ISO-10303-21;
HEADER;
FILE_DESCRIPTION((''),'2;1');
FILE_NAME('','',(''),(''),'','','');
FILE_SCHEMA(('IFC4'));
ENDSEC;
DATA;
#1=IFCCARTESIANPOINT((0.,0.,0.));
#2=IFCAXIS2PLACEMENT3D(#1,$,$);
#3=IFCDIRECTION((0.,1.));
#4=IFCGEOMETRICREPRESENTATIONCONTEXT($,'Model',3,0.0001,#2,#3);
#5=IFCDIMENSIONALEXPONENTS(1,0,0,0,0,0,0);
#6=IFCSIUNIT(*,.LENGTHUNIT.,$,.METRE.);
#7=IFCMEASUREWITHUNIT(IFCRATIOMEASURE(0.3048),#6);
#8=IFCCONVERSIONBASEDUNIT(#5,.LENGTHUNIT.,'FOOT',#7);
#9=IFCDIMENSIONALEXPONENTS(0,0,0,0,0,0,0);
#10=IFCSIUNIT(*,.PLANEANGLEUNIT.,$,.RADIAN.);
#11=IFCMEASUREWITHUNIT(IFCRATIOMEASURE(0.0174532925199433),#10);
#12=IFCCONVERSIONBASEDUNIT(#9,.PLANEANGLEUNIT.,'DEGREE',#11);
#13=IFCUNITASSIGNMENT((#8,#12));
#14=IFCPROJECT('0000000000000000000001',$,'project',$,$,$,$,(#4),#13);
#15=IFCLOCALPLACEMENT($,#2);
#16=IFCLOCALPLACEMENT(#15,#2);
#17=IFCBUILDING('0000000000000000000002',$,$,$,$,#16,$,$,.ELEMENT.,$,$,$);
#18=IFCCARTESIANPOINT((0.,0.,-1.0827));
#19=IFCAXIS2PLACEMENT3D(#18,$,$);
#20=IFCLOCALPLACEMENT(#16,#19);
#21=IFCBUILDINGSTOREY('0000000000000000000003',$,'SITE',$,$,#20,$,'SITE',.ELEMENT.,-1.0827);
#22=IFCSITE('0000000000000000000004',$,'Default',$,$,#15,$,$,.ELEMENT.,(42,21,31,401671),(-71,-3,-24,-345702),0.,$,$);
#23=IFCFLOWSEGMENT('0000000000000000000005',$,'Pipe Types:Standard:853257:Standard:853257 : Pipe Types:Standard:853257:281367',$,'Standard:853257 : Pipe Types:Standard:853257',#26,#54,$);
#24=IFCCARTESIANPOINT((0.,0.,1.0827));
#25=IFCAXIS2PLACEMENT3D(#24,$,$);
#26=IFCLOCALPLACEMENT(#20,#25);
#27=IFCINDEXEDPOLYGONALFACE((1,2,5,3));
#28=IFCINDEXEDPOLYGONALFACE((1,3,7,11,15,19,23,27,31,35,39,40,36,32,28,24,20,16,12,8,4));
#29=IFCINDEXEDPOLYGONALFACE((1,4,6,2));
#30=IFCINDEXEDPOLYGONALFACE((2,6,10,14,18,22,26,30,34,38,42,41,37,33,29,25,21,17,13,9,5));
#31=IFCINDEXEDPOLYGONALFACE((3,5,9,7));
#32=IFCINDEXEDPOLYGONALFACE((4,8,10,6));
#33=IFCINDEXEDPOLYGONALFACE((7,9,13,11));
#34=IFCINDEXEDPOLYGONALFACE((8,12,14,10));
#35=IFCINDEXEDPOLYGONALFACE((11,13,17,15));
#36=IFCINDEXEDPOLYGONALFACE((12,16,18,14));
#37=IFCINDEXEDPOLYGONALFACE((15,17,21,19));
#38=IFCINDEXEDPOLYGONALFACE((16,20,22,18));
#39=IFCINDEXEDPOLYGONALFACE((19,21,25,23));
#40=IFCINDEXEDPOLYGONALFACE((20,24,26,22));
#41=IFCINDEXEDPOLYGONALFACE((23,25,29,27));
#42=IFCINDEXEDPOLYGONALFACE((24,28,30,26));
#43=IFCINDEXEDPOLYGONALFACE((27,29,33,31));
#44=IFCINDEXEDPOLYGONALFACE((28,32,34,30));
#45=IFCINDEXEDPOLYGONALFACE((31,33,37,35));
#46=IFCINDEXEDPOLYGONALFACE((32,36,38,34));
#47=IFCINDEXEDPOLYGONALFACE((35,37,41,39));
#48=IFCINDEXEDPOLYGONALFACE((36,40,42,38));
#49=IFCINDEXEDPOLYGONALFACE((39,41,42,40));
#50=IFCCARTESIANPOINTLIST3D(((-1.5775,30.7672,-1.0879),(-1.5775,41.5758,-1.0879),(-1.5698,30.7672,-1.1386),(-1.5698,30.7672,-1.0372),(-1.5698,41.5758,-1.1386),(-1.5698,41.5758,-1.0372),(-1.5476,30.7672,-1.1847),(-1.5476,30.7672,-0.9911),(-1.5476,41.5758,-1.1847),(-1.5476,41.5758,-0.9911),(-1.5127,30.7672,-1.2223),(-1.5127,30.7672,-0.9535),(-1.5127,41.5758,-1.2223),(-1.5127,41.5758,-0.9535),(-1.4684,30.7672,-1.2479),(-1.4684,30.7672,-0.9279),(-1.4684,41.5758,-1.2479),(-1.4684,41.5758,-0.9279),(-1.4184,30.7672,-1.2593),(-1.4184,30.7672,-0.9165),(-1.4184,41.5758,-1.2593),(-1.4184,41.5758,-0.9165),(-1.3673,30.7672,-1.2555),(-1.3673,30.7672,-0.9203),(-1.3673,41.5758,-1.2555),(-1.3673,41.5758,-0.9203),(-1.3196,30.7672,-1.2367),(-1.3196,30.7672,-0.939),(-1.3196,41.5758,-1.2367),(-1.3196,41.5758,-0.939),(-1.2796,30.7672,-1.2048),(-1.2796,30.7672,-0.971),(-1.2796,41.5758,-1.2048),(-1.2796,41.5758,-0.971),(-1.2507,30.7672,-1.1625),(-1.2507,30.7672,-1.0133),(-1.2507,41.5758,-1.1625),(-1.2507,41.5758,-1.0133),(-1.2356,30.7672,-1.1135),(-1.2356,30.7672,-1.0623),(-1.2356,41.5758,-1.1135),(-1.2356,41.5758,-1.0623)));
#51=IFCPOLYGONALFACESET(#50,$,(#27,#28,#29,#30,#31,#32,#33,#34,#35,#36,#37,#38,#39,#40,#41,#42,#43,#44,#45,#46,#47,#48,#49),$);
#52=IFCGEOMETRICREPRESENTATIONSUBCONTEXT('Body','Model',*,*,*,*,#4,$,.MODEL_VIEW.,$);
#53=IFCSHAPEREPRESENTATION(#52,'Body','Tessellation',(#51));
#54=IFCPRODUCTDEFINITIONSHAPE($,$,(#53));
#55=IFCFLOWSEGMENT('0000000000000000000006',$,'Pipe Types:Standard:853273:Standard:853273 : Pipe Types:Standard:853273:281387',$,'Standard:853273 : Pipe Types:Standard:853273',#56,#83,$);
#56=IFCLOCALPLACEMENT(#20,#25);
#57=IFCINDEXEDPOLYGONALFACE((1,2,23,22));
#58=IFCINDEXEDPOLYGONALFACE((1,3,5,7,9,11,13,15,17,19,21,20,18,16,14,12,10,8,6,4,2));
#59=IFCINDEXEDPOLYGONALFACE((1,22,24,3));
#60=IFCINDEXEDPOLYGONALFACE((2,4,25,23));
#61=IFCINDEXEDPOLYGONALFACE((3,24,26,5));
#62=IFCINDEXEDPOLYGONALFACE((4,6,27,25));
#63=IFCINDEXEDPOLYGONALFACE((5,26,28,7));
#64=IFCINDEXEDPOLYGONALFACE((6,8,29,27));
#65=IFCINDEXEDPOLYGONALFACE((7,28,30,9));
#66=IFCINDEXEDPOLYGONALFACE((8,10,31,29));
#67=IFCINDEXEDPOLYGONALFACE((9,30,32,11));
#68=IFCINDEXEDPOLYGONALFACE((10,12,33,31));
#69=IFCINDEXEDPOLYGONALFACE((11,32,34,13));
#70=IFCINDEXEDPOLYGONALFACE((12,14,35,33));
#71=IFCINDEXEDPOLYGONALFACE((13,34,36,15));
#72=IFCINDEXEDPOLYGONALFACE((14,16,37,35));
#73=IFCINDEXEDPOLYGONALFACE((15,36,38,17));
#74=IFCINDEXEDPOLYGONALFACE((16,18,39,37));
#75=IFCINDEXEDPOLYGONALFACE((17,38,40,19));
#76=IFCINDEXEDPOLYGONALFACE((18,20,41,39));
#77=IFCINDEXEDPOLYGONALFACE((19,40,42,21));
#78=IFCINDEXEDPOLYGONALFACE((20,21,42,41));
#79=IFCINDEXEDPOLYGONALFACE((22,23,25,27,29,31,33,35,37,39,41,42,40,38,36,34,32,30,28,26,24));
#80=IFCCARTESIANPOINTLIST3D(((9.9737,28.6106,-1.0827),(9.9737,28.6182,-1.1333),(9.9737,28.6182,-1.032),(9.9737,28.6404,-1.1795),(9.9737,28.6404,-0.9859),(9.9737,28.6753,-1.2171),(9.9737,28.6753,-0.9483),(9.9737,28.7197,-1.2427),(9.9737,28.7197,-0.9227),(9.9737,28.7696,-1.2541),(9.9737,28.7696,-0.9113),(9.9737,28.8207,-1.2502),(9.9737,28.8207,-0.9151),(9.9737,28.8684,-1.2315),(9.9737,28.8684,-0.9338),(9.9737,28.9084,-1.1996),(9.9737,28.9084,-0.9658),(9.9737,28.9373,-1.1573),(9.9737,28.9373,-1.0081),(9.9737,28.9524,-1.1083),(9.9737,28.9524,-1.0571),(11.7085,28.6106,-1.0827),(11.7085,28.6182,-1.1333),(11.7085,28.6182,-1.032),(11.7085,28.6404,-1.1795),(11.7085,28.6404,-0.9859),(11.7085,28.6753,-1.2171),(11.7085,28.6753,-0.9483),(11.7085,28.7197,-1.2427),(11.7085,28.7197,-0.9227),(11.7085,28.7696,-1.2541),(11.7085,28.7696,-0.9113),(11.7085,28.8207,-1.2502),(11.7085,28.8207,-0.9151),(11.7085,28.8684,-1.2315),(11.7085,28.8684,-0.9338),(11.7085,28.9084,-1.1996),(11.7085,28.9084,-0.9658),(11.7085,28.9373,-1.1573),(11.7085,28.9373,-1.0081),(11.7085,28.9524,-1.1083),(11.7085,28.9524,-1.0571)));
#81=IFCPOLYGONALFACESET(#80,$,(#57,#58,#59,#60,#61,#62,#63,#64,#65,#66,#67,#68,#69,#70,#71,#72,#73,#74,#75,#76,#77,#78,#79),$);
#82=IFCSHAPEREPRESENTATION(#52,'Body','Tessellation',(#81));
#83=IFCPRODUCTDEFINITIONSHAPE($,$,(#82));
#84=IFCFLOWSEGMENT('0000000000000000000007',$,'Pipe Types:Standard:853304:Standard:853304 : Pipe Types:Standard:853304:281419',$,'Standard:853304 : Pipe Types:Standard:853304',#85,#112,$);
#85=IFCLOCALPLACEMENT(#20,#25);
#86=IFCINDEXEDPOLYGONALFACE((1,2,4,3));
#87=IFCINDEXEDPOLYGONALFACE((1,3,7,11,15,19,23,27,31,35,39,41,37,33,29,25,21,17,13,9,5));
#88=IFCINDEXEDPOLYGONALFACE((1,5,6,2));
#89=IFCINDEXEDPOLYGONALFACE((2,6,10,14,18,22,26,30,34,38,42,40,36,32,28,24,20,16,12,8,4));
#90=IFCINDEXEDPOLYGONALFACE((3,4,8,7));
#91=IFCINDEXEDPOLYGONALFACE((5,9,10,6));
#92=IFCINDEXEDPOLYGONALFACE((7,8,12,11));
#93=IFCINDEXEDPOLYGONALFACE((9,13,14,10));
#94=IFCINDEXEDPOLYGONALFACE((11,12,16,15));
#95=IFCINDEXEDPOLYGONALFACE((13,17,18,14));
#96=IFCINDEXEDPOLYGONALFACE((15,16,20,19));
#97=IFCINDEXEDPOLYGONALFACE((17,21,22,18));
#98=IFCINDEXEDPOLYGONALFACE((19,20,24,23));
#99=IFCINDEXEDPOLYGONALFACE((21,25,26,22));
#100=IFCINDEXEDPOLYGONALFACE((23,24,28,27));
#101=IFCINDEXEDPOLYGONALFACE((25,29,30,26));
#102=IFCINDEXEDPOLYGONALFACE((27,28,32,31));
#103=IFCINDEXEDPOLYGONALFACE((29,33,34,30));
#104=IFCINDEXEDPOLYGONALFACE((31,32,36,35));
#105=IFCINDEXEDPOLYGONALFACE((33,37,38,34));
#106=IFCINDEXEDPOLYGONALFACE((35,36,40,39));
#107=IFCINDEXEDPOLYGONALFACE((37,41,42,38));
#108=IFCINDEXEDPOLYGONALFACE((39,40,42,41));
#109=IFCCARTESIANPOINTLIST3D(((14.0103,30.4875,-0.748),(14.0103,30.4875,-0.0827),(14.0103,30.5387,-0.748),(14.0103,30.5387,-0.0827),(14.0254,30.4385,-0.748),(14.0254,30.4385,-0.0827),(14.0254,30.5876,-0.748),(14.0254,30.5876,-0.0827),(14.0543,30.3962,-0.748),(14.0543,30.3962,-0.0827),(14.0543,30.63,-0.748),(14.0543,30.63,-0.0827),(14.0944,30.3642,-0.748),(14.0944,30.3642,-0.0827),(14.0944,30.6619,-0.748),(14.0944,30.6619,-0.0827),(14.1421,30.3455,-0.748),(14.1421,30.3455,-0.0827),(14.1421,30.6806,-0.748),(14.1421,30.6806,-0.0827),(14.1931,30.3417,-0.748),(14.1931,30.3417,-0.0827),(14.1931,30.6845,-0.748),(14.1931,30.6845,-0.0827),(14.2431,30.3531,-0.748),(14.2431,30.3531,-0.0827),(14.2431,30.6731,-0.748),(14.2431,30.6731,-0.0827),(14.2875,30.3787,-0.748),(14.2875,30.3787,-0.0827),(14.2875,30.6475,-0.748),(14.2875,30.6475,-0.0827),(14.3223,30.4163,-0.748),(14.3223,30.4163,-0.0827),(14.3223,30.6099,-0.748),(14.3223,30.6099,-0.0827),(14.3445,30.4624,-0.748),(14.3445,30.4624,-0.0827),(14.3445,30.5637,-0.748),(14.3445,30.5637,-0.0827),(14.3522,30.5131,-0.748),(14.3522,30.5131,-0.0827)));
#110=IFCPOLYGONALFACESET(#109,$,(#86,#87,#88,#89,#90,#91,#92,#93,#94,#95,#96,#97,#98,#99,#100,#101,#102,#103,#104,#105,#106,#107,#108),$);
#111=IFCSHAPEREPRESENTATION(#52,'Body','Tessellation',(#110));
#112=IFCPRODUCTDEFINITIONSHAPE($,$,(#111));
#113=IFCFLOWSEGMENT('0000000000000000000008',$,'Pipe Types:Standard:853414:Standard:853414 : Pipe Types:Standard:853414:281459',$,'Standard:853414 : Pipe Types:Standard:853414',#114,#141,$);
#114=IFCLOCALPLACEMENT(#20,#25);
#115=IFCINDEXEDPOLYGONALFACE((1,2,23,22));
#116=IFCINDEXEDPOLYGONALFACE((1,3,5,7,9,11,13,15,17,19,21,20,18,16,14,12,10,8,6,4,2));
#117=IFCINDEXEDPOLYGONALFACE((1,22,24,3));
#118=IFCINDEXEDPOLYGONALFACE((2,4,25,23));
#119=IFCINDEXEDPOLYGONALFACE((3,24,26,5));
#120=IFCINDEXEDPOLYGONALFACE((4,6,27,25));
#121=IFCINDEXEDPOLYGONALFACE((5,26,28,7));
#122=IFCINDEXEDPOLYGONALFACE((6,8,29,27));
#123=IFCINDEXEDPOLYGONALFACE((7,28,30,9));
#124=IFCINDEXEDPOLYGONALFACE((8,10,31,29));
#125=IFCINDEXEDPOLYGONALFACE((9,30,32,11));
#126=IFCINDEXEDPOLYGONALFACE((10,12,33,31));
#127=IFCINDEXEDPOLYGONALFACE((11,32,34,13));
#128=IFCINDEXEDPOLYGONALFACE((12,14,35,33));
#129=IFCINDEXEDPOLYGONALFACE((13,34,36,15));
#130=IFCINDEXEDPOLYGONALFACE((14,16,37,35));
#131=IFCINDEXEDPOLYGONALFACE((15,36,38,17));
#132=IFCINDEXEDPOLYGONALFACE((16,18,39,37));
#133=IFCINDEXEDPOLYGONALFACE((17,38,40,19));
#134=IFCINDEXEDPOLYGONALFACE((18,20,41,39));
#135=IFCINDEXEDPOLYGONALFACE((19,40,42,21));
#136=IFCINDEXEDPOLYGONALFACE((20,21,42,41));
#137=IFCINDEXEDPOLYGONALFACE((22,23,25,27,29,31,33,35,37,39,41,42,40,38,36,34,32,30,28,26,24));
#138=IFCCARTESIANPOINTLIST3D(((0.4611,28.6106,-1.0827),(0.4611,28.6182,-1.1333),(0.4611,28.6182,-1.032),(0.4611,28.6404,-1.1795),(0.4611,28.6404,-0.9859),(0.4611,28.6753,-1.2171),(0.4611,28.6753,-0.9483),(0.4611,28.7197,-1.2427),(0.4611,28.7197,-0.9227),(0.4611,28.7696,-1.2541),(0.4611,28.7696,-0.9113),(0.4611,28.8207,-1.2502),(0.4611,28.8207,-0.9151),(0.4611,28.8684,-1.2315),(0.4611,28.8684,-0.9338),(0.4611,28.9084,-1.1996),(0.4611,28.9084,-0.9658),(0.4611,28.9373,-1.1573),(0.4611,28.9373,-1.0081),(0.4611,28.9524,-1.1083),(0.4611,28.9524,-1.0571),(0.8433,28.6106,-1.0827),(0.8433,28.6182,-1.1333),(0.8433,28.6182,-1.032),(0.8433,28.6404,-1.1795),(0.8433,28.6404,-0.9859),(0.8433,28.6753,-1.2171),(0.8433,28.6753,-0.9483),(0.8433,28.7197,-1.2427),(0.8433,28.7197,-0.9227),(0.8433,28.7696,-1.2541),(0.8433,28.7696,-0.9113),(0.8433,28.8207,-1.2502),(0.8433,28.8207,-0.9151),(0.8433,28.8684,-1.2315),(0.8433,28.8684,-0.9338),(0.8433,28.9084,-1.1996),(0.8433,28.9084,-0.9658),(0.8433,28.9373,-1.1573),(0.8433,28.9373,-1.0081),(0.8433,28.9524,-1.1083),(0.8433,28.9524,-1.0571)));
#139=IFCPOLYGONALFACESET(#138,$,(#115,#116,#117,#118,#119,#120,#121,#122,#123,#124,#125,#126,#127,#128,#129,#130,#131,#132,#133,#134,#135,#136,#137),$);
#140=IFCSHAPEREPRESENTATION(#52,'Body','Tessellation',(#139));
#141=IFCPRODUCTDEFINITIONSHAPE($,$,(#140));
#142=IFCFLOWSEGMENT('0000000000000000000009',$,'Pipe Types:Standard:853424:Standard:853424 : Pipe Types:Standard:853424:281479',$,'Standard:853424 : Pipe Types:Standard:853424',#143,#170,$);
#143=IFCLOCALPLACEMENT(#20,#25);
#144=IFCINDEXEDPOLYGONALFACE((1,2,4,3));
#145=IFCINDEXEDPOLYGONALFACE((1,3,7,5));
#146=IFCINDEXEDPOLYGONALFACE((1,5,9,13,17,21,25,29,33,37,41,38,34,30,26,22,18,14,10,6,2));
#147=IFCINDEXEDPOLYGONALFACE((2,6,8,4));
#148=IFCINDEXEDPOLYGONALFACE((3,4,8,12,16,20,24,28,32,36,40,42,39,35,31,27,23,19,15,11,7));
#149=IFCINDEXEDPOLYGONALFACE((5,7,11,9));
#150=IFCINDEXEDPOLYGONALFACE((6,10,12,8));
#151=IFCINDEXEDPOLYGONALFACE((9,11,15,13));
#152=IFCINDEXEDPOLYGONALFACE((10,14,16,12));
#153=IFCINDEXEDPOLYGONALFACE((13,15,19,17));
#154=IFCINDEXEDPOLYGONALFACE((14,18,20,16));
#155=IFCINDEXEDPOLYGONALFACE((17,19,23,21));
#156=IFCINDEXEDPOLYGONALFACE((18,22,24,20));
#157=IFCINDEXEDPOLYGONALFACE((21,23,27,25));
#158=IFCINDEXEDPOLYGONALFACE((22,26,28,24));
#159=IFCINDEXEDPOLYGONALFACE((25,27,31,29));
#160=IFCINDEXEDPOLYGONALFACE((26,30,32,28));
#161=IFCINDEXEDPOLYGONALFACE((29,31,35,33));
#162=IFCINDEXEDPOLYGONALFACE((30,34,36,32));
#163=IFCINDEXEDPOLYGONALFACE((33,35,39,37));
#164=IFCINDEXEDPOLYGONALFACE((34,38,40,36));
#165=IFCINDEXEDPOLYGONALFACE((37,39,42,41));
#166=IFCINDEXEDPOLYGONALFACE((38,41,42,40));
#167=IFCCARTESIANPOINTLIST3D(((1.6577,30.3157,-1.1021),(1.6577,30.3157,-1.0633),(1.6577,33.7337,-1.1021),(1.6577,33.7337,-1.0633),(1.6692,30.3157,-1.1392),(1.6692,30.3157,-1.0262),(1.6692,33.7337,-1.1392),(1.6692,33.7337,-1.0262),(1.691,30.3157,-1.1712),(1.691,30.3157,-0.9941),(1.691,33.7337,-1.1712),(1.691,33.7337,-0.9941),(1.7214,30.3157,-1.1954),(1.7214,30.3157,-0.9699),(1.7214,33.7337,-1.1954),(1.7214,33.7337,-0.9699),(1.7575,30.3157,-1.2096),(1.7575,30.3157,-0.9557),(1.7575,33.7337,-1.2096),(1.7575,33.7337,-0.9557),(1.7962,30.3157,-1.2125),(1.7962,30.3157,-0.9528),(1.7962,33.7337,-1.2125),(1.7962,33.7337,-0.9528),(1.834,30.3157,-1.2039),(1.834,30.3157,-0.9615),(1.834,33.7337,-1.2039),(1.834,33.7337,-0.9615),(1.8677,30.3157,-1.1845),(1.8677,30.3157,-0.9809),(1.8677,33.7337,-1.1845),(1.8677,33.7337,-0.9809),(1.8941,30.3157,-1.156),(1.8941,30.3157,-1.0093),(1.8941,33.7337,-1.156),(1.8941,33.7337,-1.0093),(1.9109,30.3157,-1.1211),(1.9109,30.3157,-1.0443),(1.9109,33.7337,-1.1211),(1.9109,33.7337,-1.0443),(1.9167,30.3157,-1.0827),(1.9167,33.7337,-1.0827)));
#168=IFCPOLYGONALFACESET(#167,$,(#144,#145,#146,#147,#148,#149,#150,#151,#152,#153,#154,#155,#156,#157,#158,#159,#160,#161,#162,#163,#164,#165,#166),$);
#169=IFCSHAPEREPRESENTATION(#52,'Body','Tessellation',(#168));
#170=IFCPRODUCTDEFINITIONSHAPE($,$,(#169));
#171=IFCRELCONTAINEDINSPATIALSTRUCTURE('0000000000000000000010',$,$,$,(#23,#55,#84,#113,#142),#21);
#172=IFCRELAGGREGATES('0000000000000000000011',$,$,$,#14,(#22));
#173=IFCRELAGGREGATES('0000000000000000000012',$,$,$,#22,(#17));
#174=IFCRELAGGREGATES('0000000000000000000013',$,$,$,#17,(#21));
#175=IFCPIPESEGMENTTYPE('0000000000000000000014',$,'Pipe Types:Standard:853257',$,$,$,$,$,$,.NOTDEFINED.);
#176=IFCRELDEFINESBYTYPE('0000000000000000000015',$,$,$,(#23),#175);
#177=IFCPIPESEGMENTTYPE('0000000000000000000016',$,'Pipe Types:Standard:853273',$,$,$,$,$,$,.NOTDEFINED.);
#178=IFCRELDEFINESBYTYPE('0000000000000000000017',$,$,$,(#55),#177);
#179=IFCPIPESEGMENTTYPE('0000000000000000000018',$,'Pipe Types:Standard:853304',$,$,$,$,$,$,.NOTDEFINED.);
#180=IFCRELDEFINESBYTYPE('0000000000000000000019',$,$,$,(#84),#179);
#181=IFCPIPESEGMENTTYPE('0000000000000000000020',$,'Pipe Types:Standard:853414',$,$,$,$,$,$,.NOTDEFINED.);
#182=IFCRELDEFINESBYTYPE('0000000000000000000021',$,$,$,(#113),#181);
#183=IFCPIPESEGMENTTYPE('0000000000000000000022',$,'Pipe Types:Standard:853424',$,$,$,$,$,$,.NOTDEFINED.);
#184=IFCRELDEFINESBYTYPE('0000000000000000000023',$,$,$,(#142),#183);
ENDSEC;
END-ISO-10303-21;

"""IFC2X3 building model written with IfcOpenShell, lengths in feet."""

from ifc_helpers import new_model, entity, si_unit, converted_unit, direction, frame, frame_2d, origin, origin_2d_with_axis, place, context, subcontext, project, spatial, circle, extrude, source, transform, mapped, type_object, type_shapes, element, save


model = new_model("IFC2X3")

# Units and contexts
model_context = context("Model", 3, precision=0.0001, world=origin(), true_north=direction((0.0, 1.0)))
body_context = subcontext(model_context, "Body", "Model", "MODEL_VIEW")
ifc_project = project(units=[converted_unit("LENGTHUNIT", "FOOT", entity("IfcRatioMeasure", 0.3048), si_unit("LENGTHUNIT", "METRE"), dimensions=[1, 0, 0, 0, 0, 0, 0]), converted_unit("PLANEANGLEUNIT", "DEGREE", entity("IfcRatioMeasure", 0.0174532925199433), si_unit("PLANEANGLEUNIT", "RADIAN"), dimensions=[0, 0, 0, 0, 0, 0, 0])], contexts=[model_context])

# Site, building, storey
site_placement = place(None, origin())
site = spatial("IfcSite", under=ifc_project, at=site_placement, Name="Default", CompositionType="ELEMENT", RefLatitude=(42, 21, 31, 401671), RefLongitude=(-71, -3, -24, -345702), RefElevation=0.0)
building_placement = place(site_placement, origin())
building = spatial("IfcBuilding", under=site, at=building_placement, CompositionType="ELEMENT")
storey_placement = place(building_placement, frame((0.0, 0.0, -1.0827)))
storey = spatial("IfcBuildingStorey", under=building, at=storey_placement, Name="SITE", LongName="SITE", CompositionType="ELEMENT", Elevation=-1.0827)

# Flow segments
pipe_segment_type_1 = type_object("IfcPipeSegmentType", Name="Pipe Types:Standard:853257", PredefinedType="NOTDEFINED")
shared_shape_1 = source(origin(), body_context, "Body", "SweptSolid", [
    extrude(circle(Radius=0.1719, at=frame_2d((0.0, 0.0), x_axis=(1.0, 0.0))), frame((-1.4056, 30.7672, -1.0879), z_axis=(0.0, 1.0, 0.0), x_axis=(-1.0, 0.0, 0.0)), (0.0, 0.0, 1.0), 10.8086),
])
type_shapes(pipe_segment_type_1, [shared_shape_1])
flow_segment_1_placement = place(storey_placement, frame((0.0, 0.0, 1.0827)))
element("IfcFlowSegment", 1, at=flow_segment_1_placement, inside=storey, type_object=pipe_segment_type_1, Name="Pipe Types:Standard:853257:Standard:853257 : Pipe Types:Standard:853257:281367", ObjectType="Standard:853257 : Pipe Types:Standard:853257", context=body_context, shape_type="MappedRepresentation", body=[
    mapped(shared_shape_1, transform((0.0, 0.0, 0.0), scale=1.0)),
])
pipe_segment_type_2 = type_object("IfcPipeSegmentType", Name="Pipe Types:Standard:853273", PredefinedType="NOTDEFINED")
shared_shape_2 = source(origin(), body_context, "Body", "SweptSolid", [
    extrude(circle(Radius=0.1719, at=frame_2d((0.0, 0.0), x_axis=(1.0, 0.0))), frame((9.9737, 28.7824, -1.0827), z_axis=(1.0, 0.0, 0.0), x_axis=(0.0, -1.0, 0.0)), (0.0, 0.0, 1.0), 1.7348),
])
type_shapes(pipe_segment_type_2, [shared_shape_2])
flow_segment_2_placement = place(storey_placement, frame((0.0, 0.0, 1.0827)))
element("IfcFlowSegment", 2, at=flow_segment_2_placement, inside=storey, type_object=pipe_segment_type_2, Name="Pipe Types:Standard:853273:Standard:853273 : Pipe Types:Standard:853273:281387", ObjectType="Standard:853273 : Pipe Types:Standard:853273", context=body_context, shape_type="MappedRepresentation", body=[
    mapped(shared_shape_2, transform((0.0, 0.0, 0.0), scale=1.0)),
])
pipe_segment_type_3 = type_object("IfcPipeSegmentType", Name="Pipe Types:Standard:853304", PredefinedType="NOTDEFINED")
shared_shape_3 = source(origin(), body_context, "Body", "SweptSolid", [
    extrude(circle(Radius=0.1719, at=origin_2d_with_axis()), frame((14.1803, 30.5131, -0.748)), (0.0, 0.0, 1.0), 0.6654),
])
type_shapes(pipe_segment_type_3, [shared_shape_3])
flow_segment_3_placement = place(storey_placement, frame((0.0, 0.0, 1.0827)))
element("IfcFlowSegment", 3, at=flow_segment_3_placement, inside=storey, type_object=pipe_segment_type_3, Name="Pipe Types:Standard:853304:Standard:853304 : Pipe Types:Standard:853304:281419", ObjectType="Standard:853304 : Pipe Types:Standard:853304", context=body_context, shape_type="MappedRepresentation", body=[
    mapped(shared_shape_3, transform((0.0, 0.0, 0.0), scale=1.0)),
])
pipe_segment_type_4 = type_object("IfcPipeSegmentType", Name="Pipe Types:Standard:853414", PredefinedType="NOTDEFINED")
shared_shape_4 = source(origin(), body_context, "Body", "SweptSolid", [
    extrude(circle(Radius=0.1719, at=frame_2d((0.0, 0.0), x_axis=(1.0, 0.0))), frame((0.4611, 28.7824, -1.0827), z_axis=(1.0, 0.0, 0.0), x_axis=(0.0, -1.0, 0.0)), (0.0, 0.0, 1.0), 0.3821),
])
type_shapes(pipe_segment_type_4, [shared_shape_4])
flow_segment_4_placement = place(storey_placement, frame((0.0, 0.0, 1.0827)))
element("IfcFlowSegment", 4, at=flow_segment_4_placement, inside=storey, type_object=pipe_segment_type_4, Name="Pipe Types:Standard:853414:Standard:853414 : Pipe Types:Standard:853414:281459", ObjectType="Standard:853414 : Pipe Types:Standard:853414", context=body_context, shape_type="MappedRepresentation", body=[
    mapped(shared_shape_4, transform((0.0, 0.0, 0.0), scale=1.0)),
])
pipe_segment_type_5 = type_object("IfcPipeSegmentType", Name="Pipe Types:Standard:853424", PredefinedType="NOTDEFINED")
shared_shape_5 = source(origin(), body_context, "Body", "SweptSolid", [
    extrude(circle(Radius=0.1302, at=frame_2d((0.0, 0.0), x_axis=(1.0, 0.0))), frame((1.7865, 30.3157, -1.0827), z_axis=(0.0, 1.0, 0.0), x_axis=(1.0, 0.0, 0.0)), (0.0, 0.0, 1.0), 3.418),
])
type_shapes(pipe_segment_type_5, [shared_shape_5])
flow_segment_5_placement = place(storey_placement, frame((0.0, 0.0, 1.0827)))
element("IfcFlowSegment", 5, at=flow_segment_5_placement, inside=storey, type_object=pipe_segment_type_5, Name="Pipe Types:Standard:853424:Standard:853424 : Pipe Types:Standard:853424:281479", ObjectType="Standard:853424 : Pipe Types:Standard:853424", context=body_context, shape_type="MappedRepresentation", body=[
    mapped(shared_shape_5, transform((0.0, 0.0, 0.0), scale=1.0)),
])

save(model, "model.ifc")
